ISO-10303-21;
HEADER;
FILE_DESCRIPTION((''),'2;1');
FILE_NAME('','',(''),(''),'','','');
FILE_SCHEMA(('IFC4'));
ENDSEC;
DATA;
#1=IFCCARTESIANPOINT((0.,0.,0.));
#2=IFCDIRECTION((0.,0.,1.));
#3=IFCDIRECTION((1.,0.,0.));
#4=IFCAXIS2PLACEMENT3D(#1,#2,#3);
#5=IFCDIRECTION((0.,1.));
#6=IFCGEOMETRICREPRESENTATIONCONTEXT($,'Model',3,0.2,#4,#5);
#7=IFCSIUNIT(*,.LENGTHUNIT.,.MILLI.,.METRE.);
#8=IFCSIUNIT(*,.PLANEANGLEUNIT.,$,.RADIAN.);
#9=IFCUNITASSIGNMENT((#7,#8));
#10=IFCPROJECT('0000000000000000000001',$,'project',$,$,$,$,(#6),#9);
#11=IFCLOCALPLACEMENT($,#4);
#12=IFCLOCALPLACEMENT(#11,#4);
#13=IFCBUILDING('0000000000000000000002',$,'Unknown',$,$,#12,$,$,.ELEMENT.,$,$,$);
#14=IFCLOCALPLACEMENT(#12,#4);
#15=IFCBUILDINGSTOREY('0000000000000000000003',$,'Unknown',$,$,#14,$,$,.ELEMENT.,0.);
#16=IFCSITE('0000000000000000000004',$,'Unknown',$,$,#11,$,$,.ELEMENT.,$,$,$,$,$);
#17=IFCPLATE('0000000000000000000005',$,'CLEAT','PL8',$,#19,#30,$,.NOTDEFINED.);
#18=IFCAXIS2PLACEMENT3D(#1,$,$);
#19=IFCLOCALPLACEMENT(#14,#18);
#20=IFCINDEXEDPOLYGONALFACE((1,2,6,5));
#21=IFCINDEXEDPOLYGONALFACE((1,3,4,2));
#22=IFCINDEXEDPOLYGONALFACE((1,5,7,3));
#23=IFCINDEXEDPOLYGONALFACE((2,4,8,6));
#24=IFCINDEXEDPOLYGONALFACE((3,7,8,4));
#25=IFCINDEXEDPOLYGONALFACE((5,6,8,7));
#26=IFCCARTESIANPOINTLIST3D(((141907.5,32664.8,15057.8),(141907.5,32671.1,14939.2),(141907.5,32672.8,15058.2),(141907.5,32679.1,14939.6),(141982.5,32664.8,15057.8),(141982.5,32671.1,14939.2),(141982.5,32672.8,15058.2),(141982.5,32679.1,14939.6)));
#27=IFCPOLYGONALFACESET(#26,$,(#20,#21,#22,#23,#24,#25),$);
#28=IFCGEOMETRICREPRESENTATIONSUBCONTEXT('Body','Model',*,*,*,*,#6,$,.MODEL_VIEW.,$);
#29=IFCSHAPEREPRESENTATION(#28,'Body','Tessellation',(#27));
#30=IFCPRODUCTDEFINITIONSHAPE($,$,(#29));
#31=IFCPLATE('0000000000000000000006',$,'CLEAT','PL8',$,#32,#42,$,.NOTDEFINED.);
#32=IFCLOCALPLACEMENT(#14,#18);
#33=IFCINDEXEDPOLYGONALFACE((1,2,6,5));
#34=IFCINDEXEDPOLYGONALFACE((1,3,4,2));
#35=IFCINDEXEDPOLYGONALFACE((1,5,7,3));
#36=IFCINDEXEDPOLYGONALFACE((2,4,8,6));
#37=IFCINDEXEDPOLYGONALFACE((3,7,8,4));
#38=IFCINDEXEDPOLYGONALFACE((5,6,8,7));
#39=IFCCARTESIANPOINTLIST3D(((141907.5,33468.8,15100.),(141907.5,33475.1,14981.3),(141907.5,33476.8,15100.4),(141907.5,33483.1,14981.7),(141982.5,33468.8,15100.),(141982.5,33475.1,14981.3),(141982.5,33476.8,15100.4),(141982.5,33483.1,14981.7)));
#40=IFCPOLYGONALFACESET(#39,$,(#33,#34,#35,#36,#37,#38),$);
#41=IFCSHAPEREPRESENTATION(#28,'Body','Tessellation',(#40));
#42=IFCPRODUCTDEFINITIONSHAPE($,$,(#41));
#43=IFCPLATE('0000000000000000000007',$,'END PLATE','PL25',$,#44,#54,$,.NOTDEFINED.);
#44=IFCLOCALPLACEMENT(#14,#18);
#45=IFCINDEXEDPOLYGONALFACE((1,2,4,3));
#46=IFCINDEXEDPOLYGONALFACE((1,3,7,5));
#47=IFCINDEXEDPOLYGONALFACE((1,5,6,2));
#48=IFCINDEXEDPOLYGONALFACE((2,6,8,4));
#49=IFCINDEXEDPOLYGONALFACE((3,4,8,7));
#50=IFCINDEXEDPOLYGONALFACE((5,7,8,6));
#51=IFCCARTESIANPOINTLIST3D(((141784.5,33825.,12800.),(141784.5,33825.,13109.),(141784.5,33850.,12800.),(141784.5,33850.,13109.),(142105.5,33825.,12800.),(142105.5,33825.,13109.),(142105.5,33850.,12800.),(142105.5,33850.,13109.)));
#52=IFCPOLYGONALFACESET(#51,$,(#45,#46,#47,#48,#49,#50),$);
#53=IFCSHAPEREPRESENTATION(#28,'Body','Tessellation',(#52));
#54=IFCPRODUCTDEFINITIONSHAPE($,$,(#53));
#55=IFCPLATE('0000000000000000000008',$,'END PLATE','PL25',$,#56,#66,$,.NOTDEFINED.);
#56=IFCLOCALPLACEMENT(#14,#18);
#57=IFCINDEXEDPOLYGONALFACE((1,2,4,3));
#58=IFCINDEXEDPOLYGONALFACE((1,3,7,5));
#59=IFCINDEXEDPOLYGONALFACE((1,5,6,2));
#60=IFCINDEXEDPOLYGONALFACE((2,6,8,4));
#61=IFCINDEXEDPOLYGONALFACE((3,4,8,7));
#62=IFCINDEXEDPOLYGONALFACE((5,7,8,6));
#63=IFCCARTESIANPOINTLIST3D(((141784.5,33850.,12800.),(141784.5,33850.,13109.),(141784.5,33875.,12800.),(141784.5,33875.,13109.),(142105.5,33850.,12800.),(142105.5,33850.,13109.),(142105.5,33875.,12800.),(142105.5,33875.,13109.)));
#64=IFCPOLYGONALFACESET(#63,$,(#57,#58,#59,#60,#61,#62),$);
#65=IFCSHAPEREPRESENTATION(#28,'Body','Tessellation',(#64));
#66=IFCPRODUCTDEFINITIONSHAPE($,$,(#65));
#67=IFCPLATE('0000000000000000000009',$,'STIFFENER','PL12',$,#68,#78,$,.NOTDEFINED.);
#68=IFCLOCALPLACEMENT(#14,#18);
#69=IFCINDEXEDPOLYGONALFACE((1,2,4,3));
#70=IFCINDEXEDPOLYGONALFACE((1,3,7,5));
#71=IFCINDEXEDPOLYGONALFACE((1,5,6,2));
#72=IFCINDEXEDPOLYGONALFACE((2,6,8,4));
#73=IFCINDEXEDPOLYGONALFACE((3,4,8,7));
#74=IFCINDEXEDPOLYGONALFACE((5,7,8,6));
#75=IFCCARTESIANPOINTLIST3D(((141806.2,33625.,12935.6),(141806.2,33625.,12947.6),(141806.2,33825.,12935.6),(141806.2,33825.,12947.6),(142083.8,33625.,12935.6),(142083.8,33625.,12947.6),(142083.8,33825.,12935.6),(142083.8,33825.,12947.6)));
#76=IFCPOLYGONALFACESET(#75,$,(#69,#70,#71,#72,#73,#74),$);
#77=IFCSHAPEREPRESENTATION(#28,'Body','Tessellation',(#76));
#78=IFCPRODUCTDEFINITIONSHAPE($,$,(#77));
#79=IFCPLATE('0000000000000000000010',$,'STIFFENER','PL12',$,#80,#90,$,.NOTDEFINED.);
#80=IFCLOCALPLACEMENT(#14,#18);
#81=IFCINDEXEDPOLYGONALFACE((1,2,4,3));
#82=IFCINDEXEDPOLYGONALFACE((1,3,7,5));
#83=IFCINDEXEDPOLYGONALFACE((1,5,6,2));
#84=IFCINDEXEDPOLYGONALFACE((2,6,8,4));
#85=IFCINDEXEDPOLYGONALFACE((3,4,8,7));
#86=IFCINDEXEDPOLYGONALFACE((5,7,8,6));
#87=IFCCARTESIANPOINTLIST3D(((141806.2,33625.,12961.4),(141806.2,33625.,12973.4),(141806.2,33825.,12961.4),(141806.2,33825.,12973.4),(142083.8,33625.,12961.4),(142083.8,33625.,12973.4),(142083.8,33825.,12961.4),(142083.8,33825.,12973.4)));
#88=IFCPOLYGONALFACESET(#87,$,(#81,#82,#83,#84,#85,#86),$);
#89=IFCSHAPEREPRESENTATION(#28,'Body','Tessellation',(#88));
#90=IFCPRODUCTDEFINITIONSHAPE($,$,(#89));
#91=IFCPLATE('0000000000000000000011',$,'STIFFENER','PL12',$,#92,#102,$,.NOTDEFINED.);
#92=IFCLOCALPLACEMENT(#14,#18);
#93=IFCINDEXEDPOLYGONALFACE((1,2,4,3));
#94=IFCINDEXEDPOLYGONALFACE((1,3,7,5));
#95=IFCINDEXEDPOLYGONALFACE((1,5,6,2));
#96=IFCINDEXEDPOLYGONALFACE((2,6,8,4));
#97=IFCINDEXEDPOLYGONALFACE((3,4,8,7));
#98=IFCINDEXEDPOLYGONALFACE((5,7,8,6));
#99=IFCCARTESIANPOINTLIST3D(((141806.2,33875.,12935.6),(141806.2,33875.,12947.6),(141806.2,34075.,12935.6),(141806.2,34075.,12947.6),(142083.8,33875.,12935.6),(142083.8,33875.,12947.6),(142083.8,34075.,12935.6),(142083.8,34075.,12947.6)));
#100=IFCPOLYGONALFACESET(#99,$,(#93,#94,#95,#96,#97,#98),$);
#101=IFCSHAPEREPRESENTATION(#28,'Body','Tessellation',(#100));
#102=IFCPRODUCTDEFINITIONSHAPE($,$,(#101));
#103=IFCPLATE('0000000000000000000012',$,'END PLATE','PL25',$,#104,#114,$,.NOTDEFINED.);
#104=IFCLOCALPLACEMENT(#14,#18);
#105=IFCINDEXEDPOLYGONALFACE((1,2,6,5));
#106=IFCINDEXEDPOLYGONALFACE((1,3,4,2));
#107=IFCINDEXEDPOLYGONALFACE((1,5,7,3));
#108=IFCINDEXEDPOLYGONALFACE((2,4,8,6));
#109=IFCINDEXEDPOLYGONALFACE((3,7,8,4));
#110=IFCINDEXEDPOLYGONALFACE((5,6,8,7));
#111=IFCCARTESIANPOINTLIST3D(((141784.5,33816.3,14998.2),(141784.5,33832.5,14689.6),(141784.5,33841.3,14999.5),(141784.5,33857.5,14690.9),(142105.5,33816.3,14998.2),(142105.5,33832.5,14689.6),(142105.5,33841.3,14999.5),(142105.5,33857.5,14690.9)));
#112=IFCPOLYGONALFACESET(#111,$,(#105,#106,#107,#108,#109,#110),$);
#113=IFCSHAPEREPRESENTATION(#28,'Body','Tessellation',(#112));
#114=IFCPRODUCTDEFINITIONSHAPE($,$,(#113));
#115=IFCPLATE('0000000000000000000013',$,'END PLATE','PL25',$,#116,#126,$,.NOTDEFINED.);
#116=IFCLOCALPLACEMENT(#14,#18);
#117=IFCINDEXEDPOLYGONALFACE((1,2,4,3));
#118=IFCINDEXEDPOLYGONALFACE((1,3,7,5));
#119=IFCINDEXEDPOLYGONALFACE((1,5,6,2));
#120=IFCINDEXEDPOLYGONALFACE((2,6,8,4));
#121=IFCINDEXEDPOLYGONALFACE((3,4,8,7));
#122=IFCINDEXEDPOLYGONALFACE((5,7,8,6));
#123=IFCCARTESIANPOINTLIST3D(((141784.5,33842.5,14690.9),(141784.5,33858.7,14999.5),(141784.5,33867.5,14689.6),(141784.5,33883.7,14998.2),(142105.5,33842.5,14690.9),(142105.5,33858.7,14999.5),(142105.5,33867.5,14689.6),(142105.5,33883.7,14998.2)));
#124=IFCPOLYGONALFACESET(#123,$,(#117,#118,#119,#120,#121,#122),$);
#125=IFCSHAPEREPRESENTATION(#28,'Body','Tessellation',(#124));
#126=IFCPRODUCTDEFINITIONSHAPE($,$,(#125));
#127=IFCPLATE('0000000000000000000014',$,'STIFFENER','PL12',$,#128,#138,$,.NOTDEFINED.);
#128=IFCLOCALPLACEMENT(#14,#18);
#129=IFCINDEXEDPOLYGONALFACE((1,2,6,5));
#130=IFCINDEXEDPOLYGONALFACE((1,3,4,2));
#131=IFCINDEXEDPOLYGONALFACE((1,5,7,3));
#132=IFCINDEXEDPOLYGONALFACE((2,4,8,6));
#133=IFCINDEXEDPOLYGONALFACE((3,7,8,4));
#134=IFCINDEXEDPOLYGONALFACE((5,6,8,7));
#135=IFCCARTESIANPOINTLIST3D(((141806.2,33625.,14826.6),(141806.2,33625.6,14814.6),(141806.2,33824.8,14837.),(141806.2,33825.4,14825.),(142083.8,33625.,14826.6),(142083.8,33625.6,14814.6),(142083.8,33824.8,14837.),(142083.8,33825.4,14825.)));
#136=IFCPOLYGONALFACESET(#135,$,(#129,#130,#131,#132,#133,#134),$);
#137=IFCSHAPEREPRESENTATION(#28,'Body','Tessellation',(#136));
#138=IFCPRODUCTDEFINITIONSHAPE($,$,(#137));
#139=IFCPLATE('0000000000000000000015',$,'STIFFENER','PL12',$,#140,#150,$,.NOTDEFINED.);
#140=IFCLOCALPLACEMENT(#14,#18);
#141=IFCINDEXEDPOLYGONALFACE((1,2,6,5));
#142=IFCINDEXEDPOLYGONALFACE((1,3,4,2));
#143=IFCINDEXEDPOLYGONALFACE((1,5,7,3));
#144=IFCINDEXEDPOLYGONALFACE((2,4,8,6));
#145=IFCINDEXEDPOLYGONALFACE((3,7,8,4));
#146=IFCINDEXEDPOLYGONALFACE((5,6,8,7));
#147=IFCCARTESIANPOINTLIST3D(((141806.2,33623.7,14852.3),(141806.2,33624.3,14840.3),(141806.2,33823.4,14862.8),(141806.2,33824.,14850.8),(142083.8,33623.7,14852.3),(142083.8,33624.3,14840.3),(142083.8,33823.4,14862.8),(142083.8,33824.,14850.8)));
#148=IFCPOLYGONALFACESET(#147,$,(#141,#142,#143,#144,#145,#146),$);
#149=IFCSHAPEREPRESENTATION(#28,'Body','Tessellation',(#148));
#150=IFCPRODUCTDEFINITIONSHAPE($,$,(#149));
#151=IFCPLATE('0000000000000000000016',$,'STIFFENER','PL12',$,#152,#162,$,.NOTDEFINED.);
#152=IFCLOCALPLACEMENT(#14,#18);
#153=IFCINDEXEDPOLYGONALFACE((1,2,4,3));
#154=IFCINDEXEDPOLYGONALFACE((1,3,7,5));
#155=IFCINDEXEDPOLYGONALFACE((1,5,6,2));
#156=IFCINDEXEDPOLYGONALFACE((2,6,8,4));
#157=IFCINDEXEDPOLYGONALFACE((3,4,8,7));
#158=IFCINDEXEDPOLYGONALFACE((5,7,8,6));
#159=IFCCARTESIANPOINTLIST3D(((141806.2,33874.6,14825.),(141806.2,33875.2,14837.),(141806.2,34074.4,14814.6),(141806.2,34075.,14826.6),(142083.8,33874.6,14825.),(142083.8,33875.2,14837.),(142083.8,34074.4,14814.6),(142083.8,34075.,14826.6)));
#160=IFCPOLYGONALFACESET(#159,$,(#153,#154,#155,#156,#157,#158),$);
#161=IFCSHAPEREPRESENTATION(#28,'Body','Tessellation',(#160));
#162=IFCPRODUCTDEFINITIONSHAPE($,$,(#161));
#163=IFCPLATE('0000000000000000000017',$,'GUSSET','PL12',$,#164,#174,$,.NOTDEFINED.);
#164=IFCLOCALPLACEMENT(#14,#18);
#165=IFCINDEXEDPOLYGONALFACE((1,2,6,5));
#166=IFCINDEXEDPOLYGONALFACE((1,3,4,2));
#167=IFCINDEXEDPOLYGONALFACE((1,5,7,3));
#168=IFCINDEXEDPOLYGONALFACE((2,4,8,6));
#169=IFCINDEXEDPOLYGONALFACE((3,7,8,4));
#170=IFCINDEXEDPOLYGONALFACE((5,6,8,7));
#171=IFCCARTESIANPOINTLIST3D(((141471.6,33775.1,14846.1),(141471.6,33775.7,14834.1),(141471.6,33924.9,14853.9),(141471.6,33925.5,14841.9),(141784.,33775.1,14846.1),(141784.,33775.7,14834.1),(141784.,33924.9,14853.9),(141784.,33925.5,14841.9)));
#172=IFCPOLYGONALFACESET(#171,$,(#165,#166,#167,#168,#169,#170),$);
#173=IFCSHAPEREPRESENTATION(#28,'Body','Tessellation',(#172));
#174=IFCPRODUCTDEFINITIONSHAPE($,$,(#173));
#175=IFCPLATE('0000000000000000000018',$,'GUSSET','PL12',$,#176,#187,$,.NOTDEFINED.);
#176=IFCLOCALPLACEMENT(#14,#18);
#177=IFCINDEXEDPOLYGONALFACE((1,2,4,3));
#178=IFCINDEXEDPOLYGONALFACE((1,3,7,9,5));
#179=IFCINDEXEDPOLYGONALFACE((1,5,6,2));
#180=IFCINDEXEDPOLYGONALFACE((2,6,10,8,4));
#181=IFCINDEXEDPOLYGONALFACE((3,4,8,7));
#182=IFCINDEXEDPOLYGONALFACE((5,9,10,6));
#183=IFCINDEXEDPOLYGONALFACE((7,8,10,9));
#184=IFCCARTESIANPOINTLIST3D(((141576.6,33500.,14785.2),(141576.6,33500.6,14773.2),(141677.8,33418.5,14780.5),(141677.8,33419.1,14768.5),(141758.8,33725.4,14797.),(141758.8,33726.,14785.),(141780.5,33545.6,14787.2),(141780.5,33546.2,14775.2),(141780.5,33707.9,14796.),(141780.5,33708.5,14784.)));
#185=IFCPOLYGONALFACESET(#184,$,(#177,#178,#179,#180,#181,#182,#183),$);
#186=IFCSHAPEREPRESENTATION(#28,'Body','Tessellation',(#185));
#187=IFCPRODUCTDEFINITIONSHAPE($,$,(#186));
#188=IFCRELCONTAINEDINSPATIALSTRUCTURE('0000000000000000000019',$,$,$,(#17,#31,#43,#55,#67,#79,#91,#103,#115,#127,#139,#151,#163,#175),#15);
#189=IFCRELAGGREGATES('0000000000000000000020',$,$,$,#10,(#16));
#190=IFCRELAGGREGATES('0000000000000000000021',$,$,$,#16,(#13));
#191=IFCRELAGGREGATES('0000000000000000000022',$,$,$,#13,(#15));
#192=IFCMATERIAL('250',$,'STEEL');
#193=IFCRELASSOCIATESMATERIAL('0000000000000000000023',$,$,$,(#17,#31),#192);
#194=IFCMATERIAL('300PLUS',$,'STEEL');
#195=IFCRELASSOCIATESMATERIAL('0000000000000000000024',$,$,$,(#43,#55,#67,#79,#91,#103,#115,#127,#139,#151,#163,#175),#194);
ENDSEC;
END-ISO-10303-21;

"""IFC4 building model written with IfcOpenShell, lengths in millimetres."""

from ifc_helpers import new_model, si_unit, direction, frame, origin_with_axes, place, context, subcontext, project, spatial, line, indexed_curve, outline, extrude, material, element, save


model = new_model("IFC4")

# Units and contexts
model_context = context("Model", 3, precision=0.2, world=origin_with_axes(), true_north=direction((0.0, 1.0)))
body_context = subcontext(model_context, "Body", "Model", "MODEL_VIEW")
ifc_project = project(units=[si_unit("LENGTHUNIT", "METRE", prefix="MILLI"), si_unit("PLANEANGLEUNIT", "RADIAN")], contexts=[model_context])

# Site, building, storey
site_placement = place(None, origin_with_axes())
site = spatial("IfcSite", under=ifc_project, at=site_placement, Name="Unknown", CompositionType="ELEMENT")
building_placement = place(site_placement, origin_with_axes())
building = spatial("IfcBuilding", under=site, at=building_placement, Name="Unknown", CompositionType="ELEMENT")
storey_placement = place(building_placement, origin_with_axes())
storey = spatial("IfcBuildingStorey", under=building, at=storey_placement, Name="Unknown", CompositionType="ELEMENT", Elevation=0.0)

# Shared definitions
ifc_material_1 = material(Name="300PLUS", Category="STEEL")

# Plates
ifc_material_2 = material(Name="250", Category="STEEL")
plate_1_placement = place(storey_placement, frame((141907.5, 32668.8, 15058.0), z_axis=(0.0, 0.998592, 0.053045), x_axis=(1.0, 0.0, 0.0)))
element("IfcPlate", 1, at=plate_1_placement, inside=storey, material=ifc_material_2, Name="CLEAT", Description="PL8", PredefinedType="NOTDEFINED", context=body_context, shape_type="SolidModel", body=[
    extrude(outline(indexed_curve([(0.0, 0.0), (75.0, 0.0), (75.0, 118.8), (0.0, 118.8)], segments=[line(1, 2, 3, 4, 1)])), frame((0.0, 0.0, 4.0), z_axis=(0.0, 0.0, 1.0), x_axis=(1.0, 0.0, 0.0)), (0.0, 0.0, -1.0), 8.0),
])
plate_2_placement = place(storey_placement, frame((141907.5, 33472.8, 15100.2), z_axis=(0.0, 0.998594, 0.053), x_axis=(1.0, 0.0, 0.0)))
element("IfcPlate", 2, at=plate_2_placement, inside=storey, material=ifc_material_2, Name="CLEAT", Description="PL8", PredefinedType="NOTDEFINED", context=body_context, shape_type="SolidModel", body=[
    extrude(outline(indexed_curve([(0.0, 0.0), (75.0, 0.0), (75.0, 118.9), (0.0, 118.9)], segments=[line(1, 2, 3, 4, 1)])), frame((0.0, 0.0, 4.0), z_axis=(0.0, 0.0, 1.0), x_axis=(1.0, 0.0, 0.0)), (0.0, 0.0, -1.0), 8.0),
])
for number, where, z_axis, x_axis, name in (
    (3, (142105.5, 33837.5, 12800.0), (0.0, -1.0, 0.0), (0.0, 0.0, 1.0), "END PLATE"),
    (4, (141784.5, 33862.5, 12800.0), (0.0, 1.0, 0.0), (0.0, 0.0, 1.0), "END PLATE"),
):
    element("IfcPlate", number, at=place(storey_placement, frame(where, z_axis=z_axis, x_axis=x_axis)), inside=storey, material=ifc_material_1, Name=name, Description="PL25", PredefinedType="NOTDEFINED", context=body_context, shape_type="SolidModel", body=[
        extrude(outline(indexed_curve([(0.0, 0.0), (309.0, 0.0), (309.0, 321.0), (0.0, 321.0)], segments=[line(1, 2, 3, 4, 1)])), frame((0.0, 0.0, 12.5), z_axis=(0.0, 0.0, 1.0), x_axis=(1.0, 0.0, 0.0)), (0.0, 0.0, -1.0), 25.0),
    ])
for number, where, z_axis, x_axis, name in (
    (5, (142083.8, 33625.0, 12941.6), (0.0, 0.0, 1.0), (0.0, 1.0, 0.0), "STIFFENER"),
    (6, (142083.8, 33625.0, 12967.4), (0.0, 0.0, 1.0), (0.0, 1.0, 0.0), "STIFFENER"),
    (7, (141806.2, 34075.0, 12941.6), (0.0, 0.0, 1.0), (0.0, -1.0, 0.0), "STIFFENER"),
):
    element("IfcPlate", number, at=place(storey_placement, frame(where, z_axis=z_axis, x_axis=x_axis)), inside=storey, material=ifc_material_1, Name=name, Description="PL12", PredefinedType="NOTDEFINED", context=body_context, shape_type="SolidModel", body=[
        extrude(outline(indexed_curve([(0.0, 0.0), (200.0, 0.0), (200.0, 277.6), (0.0, 277.6)], segments=[line(1, 2, 3, 4, 1)])), frame((0.0, 0.0, 6.0), z_axis=(0.0, 0.0, 1.0), x_axis=(1.0, 0.0, 0.0)), (0.0, 0.0, -1.0), 12.0),
    ])
for number, where, z_axis, x_axis, name in (
    (8, (141784.5, 33845.0, 14690.3), (0.0, 0.998625, 0.052423), (0.0, -0.052423, 0.998625), "END PLATE"),
    (9, (142105.5, 33855.0, 14690.3), (0.0, -0.998625, 0.052423), (0.0, 0.052423, 0.998625), "END PLATE"),
):
    element("IfcPlate", number, at=place(storey_placement, frame(where, z_axis=z_axis, x_axis=x_axis)), inside=storey, material=ifc_material_1, Name=name, Description="PL25", PredefinedType="NOTDEFINED", context=body_context, shape_type="SolidModel", body=[
        extrude(outline(indexed_curve([(0.0, 0.0), (309.0, 0.0), (309.0, 321.0), (0.0, 321.0)], segments=[line(1, 2, 3, 4, 1)])), frame((0.0, 0.0, 12.5), z_axis=(0.0, 0.0, 1.0), x_axis=(1.0, 0.0, 0.0)), (0.0, 0.0, -1.0), 25.0),
    ])
plate_3_placement = place(storey_placement, frame((142083.8, 33625.3, 14820.6), z_axis=(0.0, -0.051982, 0.998648), x_axis=(0.0, 0.998648, 0.051982)))
element("IfcPlate", 10, at=plate_3_placement, inside=storey, material=ifc_material_1, Name="STIFFENER", Description="PL12", PredefinedType="NOTDEFINED", context=body_context, shape_type="SolidModel", body=[
    extrude(outline(indexed_curve([(0.0, 0.0), (200.1, 0.0), (200.1, 277.6), (0.0, 277.6)], segments=[line(1, 2, 3, 4, 1)])), frame((0.0, 0.0, 6.0), z_axis=(0.0, 0.0, 1.0), x_axis=(1.0, 0.0, 0.0)), (0.0, 0.0, -1.0), 12.0),
])
plate_4_placement = place(storey_placement, frame((142083.8, 33624.0, 14846.3), z_axis=(0.0, -0.052506, 0.998621), x_axis=(0.0, 0.998621, 0.052506)))
element("IfcPlate", 11, at=plate_4_placement, inside=storey, material=ifc_material_1, Name="STIFFENER", Description="PL12", PredefinedType="NOTDEFINED", context=body_context, shape_type="SolidModel", body=[
    extrude(outline(indexed_curve([(0.0, 0.0), (200.0, 0.0), (200.0, 277.6), (0.0, 277.6)], segments=[line(1, 2, 3, 4, 1)])), frame((0.0, 0.0, 6.0), z_axis=(0.0, 0.0, 1.0), x_axis=(1.0, 0.0, 0.0)), (0.0, 0.0, -1.0), 12.0),
])
plate_5_placement = place(storey_placement, frame((141806.2, 34074.7, 14820.6), z_axis=(0.0, 0.051982, 0.998648), x_axis=(0.0, -0.998648, 0.051982)))
element("IfcPlate", 12, at=plate_5_placement, inside=storey, material=ifc_material_1, Name="STIFFENER", Description="PL12", PredefinedType="NOTDEFINED", context=body_context, shape_type="SolidModel", body=[
    extrude(outline(indexed_curve([(0.0, 0.0), (200.1, 0.0), (200.1, 277.6), (0.0, 277.6)], segments=[line(1, 2, 3, 4, 1)])), frame((0.0, 0.0, 6.0), z_axis=(0.0, 0.0, 1.0), x_axis=(1.0, 0.0, 0.0)), (0.0, 0.0, -1.0), 12.0),
])
plate_6_placement = place(storey_placement, frame((141784.0, 33925.2, 14847.9), z_axis=(0.0, -0.051999, 0.998647), x_axis=(-1.0, 0.0, 0.0)))
element("IfcPlate", 13, at=plate_6_placement, inside=storey, material=ifc_material_1, Name="GUSSET", Description="PL12", PredefinedType="NOTDEFINED", context=body_context, shape_type="SolidModel", body=[
    extrude(outline(indexed_curve([(0.0, 0.0), (312.4, 0.0), (312.4, 150.0), (0.0, 150.0)], segments=[line(1, 2, 3, 4, 1)])), frame((0.0, 0.0, 6.0), z_axis=(0.0, 0.0, 1.0), x_axis=(1.0, 0.0, 0.0)), (0.0, 0.0, -1.0), 12.0),
])
plate_7_placement = place(storey_placement, frame((141758.8, 33725.7, 14791.0), z_axis=(0.002336, -0.054162, 0.998529), x_axis=(-0.628122, -0.777051, -0.04068)))
element("IfcPlate", 14, at=plate_7_placement, inside=storey, material=ifc_material_1, Name="GUSSET", Description="PL12", PredefinedType="NOTDEFINED", context=body_context, shape_type="SolidModel", body=[
    extrude(outline(indexed_curve([(0.0, 0.0), (290.1, 0.0), (290.0, 130.0), (126.5, 130.0), (0.0, 27.9)], segments=[line(1, 2, 3, 4, 5, 1)])), frame((0.0, 0.0, 6.0), z_axis=(0.0, 0.0, 1.0), x_axis=(1.0, 0.0, 0.0)), (0.0, 0.0, -1.0), 12.0),
])

save(model, "model.ifc")
